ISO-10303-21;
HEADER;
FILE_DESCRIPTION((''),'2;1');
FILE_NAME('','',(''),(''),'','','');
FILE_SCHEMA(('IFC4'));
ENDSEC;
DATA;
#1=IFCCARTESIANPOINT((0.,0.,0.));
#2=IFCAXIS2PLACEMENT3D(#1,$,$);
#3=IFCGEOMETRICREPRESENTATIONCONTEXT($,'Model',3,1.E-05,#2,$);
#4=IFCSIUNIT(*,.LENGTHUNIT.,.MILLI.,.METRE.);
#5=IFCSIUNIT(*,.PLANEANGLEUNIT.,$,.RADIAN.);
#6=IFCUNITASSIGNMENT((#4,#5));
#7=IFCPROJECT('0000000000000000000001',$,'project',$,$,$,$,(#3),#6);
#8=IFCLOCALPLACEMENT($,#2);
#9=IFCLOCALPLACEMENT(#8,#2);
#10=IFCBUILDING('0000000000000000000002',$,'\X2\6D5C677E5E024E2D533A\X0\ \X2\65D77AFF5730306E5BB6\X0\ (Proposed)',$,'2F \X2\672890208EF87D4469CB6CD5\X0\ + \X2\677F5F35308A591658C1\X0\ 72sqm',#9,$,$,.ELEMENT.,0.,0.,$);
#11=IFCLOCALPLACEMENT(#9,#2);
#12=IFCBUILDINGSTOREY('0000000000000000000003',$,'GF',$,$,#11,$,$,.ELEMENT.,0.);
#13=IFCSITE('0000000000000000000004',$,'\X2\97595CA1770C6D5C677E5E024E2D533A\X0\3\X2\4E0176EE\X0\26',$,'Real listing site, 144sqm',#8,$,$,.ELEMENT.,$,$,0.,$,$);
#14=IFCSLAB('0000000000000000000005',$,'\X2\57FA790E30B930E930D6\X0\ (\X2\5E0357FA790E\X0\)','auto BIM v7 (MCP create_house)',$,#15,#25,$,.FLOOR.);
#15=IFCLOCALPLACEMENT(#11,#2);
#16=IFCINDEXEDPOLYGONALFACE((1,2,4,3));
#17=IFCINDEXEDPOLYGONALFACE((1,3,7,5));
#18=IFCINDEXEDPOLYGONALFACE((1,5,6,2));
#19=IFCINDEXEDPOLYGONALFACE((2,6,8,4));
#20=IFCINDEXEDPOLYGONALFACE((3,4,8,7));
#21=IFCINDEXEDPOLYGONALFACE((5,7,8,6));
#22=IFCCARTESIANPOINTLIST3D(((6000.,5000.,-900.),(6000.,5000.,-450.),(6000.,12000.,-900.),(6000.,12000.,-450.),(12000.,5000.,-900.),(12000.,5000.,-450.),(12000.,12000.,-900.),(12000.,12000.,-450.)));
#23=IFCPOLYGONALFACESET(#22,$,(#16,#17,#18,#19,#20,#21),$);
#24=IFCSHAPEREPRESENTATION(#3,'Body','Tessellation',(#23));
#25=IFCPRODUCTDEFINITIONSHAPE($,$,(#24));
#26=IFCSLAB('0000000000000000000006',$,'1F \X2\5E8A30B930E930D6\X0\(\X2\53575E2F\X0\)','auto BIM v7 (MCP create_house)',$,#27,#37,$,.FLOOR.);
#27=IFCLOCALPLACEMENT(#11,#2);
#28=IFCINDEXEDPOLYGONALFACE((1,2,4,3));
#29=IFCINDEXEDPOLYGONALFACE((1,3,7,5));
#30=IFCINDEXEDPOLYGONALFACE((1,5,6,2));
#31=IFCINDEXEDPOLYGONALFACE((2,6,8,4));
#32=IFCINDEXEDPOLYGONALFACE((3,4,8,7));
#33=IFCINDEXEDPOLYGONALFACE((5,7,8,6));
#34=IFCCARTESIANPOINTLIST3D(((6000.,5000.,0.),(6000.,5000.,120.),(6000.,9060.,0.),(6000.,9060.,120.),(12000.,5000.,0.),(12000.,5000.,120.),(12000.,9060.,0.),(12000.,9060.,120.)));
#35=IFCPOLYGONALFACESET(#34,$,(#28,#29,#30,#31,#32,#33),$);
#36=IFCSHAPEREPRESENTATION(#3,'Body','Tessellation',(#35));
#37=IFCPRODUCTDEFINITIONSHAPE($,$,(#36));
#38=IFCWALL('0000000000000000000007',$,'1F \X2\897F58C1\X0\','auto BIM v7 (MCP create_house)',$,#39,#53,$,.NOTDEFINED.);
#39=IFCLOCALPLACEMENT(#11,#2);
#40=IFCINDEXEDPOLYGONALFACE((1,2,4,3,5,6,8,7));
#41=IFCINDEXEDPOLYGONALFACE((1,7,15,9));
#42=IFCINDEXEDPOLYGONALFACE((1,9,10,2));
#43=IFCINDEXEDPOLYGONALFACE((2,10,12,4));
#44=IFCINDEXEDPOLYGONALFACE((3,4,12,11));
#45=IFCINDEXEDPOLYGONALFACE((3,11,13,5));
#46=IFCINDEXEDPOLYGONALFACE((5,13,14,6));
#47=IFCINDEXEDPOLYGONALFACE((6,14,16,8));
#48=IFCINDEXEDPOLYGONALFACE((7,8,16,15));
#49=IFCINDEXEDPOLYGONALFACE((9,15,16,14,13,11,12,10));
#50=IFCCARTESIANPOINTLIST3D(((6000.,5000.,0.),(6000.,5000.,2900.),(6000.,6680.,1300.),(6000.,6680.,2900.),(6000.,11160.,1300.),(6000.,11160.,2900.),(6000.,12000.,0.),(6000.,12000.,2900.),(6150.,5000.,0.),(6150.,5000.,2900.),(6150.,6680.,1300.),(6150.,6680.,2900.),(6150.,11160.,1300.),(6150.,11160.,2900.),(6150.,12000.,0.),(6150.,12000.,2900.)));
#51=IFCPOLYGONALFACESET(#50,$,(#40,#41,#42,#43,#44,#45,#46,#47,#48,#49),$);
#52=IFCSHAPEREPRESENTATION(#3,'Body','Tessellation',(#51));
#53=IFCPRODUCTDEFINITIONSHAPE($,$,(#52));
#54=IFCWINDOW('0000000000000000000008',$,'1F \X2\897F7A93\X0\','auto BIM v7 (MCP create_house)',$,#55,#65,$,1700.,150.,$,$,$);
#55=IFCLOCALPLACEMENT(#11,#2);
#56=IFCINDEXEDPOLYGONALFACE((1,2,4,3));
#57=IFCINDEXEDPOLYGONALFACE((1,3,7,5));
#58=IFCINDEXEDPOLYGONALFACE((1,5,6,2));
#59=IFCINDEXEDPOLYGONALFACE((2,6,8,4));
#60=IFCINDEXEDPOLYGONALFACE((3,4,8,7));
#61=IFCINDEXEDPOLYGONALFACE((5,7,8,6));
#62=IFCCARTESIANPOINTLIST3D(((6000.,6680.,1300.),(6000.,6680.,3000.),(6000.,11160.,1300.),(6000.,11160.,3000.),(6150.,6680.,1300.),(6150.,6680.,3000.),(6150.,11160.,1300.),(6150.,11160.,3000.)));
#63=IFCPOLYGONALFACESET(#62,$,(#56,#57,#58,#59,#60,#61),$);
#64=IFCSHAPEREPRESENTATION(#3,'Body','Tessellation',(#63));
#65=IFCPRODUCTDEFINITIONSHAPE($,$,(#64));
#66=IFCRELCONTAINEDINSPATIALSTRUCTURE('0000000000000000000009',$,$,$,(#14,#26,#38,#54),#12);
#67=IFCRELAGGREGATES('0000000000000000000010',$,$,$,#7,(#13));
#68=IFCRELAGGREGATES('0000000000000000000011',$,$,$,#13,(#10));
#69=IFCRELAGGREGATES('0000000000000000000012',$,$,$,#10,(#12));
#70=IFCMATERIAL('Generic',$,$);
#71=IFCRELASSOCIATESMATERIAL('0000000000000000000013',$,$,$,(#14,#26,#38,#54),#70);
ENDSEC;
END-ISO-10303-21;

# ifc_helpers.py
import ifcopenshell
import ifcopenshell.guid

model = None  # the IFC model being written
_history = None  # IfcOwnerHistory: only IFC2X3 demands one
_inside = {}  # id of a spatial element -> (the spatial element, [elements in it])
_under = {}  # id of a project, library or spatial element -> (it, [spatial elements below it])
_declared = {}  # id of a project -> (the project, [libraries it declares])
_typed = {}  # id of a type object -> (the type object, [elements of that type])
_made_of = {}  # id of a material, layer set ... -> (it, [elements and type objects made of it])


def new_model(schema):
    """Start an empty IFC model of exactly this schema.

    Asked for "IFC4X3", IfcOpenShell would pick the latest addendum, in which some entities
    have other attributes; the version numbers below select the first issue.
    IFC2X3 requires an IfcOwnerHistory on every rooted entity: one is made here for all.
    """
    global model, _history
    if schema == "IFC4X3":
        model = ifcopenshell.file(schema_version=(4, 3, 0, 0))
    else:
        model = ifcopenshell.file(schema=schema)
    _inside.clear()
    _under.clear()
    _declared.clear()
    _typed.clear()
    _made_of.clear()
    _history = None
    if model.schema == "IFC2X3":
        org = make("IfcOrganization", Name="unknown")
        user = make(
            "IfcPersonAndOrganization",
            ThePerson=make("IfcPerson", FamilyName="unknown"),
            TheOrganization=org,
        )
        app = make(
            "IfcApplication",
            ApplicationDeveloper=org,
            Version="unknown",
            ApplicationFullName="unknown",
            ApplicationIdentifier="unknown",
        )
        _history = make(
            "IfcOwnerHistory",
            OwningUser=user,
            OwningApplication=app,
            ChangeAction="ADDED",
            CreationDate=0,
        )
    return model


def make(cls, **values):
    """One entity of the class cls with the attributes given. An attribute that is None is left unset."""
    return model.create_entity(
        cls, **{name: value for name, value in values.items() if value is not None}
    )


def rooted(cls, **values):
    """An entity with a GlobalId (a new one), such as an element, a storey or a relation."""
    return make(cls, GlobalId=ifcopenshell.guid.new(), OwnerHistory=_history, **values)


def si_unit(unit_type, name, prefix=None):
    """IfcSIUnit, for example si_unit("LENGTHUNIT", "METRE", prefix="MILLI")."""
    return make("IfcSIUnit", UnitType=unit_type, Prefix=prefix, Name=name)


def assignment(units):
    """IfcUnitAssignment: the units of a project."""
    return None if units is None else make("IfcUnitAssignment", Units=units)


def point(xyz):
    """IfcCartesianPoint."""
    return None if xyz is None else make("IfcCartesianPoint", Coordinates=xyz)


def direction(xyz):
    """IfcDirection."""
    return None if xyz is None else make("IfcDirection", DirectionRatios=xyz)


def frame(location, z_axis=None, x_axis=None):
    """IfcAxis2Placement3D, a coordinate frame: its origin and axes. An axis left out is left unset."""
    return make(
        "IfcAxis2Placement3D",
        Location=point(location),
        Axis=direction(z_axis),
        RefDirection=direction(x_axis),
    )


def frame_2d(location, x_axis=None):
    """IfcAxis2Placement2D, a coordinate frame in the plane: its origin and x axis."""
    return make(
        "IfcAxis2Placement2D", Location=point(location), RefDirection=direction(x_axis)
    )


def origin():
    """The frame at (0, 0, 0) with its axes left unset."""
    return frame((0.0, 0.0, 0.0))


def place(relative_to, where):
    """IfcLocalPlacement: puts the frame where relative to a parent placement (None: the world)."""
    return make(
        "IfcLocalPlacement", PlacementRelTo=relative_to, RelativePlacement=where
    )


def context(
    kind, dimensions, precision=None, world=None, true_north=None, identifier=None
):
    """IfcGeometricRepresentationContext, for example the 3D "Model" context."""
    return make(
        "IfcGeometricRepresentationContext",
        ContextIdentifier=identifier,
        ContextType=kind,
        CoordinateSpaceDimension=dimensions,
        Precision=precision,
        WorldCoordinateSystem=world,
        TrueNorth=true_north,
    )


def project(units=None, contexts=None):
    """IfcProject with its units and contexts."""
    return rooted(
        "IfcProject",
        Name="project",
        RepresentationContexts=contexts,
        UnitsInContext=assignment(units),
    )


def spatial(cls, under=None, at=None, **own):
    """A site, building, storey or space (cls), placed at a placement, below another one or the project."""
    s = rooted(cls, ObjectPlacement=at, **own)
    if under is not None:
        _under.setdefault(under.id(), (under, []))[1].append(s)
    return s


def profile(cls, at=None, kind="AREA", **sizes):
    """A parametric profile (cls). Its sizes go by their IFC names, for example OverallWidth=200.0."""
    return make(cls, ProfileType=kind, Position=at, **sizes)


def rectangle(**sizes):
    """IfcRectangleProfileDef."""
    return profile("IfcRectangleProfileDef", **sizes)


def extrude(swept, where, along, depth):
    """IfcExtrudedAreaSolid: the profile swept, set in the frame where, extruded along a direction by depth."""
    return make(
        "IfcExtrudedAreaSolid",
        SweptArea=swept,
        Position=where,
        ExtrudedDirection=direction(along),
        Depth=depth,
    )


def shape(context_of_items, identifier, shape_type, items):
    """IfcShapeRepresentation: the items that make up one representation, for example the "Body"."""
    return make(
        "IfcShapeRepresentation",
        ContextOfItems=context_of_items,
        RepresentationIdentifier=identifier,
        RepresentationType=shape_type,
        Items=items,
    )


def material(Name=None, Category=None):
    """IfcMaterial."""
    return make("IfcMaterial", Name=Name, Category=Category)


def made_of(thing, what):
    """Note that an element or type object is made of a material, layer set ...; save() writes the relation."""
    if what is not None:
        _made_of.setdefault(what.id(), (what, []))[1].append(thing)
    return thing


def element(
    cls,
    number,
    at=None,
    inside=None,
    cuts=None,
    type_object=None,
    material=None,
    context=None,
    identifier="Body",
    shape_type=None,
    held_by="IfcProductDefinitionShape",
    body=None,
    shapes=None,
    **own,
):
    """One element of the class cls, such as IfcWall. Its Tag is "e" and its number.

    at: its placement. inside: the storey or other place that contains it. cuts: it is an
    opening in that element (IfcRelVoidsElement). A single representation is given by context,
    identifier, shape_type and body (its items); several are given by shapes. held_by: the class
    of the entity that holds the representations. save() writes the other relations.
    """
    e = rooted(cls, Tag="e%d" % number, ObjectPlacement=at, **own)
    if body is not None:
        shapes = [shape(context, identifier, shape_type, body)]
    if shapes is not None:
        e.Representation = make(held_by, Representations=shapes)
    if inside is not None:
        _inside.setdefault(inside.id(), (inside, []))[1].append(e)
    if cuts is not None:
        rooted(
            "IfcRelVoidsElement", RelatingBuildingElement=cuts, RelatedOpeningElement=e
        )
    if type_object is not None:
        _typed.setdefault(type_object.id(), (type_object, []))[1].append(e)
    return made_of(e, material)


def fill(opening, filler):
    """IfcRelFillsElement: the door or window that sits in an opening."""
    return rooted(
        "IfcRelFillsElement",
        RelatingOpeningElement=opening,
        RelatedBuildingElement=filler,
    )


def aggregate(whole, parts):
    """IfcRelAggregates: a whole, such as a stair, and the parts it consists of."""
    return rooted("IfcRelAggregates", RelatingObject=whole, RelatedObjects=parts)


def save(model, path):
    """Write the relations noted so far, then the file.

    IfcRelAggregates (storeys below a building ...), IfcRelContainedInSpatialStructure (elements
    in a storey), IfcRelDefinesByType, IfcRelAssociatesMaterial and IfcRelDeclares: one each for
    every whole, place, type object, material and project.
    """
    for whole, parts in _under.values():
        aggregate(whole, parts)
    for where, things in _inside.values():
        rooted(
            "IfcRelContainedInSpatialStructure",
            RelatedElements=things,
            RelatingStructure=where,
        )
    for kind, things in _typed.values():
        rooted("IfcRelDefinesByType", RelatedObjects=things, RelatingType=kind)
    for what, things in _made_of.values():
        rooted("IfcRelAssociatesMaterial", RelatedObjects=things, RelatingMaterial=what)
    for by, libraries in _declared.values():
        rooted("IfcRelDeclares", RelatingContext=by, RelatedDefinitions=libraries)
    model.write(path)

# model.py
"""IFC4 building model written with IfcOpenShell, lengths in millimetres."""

from ifc_helpers import new_model, si_unit, frame, frame_2d, origin, place, context, project, spatial, rectangle, extrude, material, element, fill, save


model = new_model("IFC4")

# Units and contexts
model_context = context("Model", 3, precision=1e-05, world=origin())
ifc_project = project(units=[si_unit("LENGTHUNIT", "METRE", prefix="MILLI"), si_unit("PLANEANGLEUNIT", "RADIAN")], contexts=[model_context])

# Site, building, storey
site_placement = place(None, origin())
site = spatial("IfcSite", under=ifc_project, at=site_placement, Name="静岡県浜松市中区3丁目26", ObjectType="Real listing site, 144sqm", CompositionType="ELEMENT", RefElevation=0.0)
building_placement = place(site_placement, origin())
building = spatial("IfcBuilding", under=site, at=building_placement, Name="浜松市中区 旗竿地の家 (Proposed)", ObjectType="2F 木造軸組構法 + 板張り外壁 72sqm", CompositionType="ELEMENT", ElevationOfRefHeight=0.0, ElevationOfTerrain=0.0)
storey_placement = place(building_placement, origin())
storey = spatial("IfcBuildingStorey", under=building, at=storey_placement, Name="GF", CompositionType="ELEMENT", Elevation=0.0)

# Slabs
ifc_material = material(Name="Generic")
slab_1_placement = place(storey_placement, frame((3000.0, 2500.0, -450.0)))
element("IfcSlab", 1, at=slab_1_placement, inside=storey, material=ifc_material, Name="基礎スラブ (布基礎)", Description="auto BIM v7 (MCP create_house)", PredefinedType="FLOOR", context=model_context, shape_type="SweptSolid", body=[
    extrude(rectangle(XDim=6000.0, YDim=7000.0, at=frame_2d((3000.0, 3500.0))), frame((3000.0, 2500.0, -450.0)), (0.0, 0.0, 1.0), 450.0),
])
slab_2_placement = place(storey_placement, frame((3000.0, 2500.0, 0.0)))
element("IfcSlab", 2, at=slab_2_placement, inside=storey, material=ifc_material, Name="1F 床スラブ(南帯)", Description="auto BIM v7 (MCP create_house)", PredefinedType="FLOOR", context=model_context, shape_type="SweptSolid", body=[
    extrude(rectangle(XDim=6000.0, YDim=4060.0, at=frame_2d((3000.0, 2030.0))), frame((3000.0, 2500.0, 0.0)), (0.0, 0.0, 1.0), 120.0),
])

# Wall, opening, window
wall_1_placement = place(storey_placement, frame((3000.0, 2500.0, 0.0)))
wall_1 = element("IfcWall", 3, at=wall_1_placement, inside=storey, material=ifc_material, Name="1F 西壁", Description="auto BIM v7 (MCP create_house)", PredefinedType="NOTDEFINED", context=model_context, shape_type="SweptSolid", body=[
    extrude(rectangle(XDim=150.0, YDim=7000.0, at=frame_2d((75.0, 3500.0))), frame((3000.0, 2500.0, 0.0)), (0.0, 0.0, 1.0), 2900.0),
])
opening_1_placement = place(storey_placement, frame((3000.0, 3340.0, 650.0)))
opening_1 = element("IfcOpeningElement", 4, at=opening_1_placement, cuts=wall_1, PredefinedType="NOTDEFINED", context=model_context, shape_type="SweptSolid", body=[
    extrude(rectangle(XDim=150.0, YDim=4480.0, at=frame_2d((75.0, 2240.0))), frame((3000.0, 3340.0, 650.0)), (0.0, 0.0, 1.0), 1700.0),
])
window_1_placement = place(storey_placement, frame((3000.0, 3340.0, 650.0)))
window_1 = element("IfcWindow", 5, at=window_1_placement, inside=storey, material=ifc_material, Name="1F 西窓", Description="auto BIM v7 (MCP create_house)", OverallHeight=1700.0, OverallWidth=150.0, context=model_context, shape_type="SweptSolid", body=[
    extrude(rectangle(XDim=150.0, YDim=4480.0, at=frame_2d((75.0, 2240.0))), frame((3000.0, 3340.0, 650.0)), (0.0, 0.0, 1.0), 1700.0),
])
fill(opening_1, window_1)

save(model, "model.ifc")
